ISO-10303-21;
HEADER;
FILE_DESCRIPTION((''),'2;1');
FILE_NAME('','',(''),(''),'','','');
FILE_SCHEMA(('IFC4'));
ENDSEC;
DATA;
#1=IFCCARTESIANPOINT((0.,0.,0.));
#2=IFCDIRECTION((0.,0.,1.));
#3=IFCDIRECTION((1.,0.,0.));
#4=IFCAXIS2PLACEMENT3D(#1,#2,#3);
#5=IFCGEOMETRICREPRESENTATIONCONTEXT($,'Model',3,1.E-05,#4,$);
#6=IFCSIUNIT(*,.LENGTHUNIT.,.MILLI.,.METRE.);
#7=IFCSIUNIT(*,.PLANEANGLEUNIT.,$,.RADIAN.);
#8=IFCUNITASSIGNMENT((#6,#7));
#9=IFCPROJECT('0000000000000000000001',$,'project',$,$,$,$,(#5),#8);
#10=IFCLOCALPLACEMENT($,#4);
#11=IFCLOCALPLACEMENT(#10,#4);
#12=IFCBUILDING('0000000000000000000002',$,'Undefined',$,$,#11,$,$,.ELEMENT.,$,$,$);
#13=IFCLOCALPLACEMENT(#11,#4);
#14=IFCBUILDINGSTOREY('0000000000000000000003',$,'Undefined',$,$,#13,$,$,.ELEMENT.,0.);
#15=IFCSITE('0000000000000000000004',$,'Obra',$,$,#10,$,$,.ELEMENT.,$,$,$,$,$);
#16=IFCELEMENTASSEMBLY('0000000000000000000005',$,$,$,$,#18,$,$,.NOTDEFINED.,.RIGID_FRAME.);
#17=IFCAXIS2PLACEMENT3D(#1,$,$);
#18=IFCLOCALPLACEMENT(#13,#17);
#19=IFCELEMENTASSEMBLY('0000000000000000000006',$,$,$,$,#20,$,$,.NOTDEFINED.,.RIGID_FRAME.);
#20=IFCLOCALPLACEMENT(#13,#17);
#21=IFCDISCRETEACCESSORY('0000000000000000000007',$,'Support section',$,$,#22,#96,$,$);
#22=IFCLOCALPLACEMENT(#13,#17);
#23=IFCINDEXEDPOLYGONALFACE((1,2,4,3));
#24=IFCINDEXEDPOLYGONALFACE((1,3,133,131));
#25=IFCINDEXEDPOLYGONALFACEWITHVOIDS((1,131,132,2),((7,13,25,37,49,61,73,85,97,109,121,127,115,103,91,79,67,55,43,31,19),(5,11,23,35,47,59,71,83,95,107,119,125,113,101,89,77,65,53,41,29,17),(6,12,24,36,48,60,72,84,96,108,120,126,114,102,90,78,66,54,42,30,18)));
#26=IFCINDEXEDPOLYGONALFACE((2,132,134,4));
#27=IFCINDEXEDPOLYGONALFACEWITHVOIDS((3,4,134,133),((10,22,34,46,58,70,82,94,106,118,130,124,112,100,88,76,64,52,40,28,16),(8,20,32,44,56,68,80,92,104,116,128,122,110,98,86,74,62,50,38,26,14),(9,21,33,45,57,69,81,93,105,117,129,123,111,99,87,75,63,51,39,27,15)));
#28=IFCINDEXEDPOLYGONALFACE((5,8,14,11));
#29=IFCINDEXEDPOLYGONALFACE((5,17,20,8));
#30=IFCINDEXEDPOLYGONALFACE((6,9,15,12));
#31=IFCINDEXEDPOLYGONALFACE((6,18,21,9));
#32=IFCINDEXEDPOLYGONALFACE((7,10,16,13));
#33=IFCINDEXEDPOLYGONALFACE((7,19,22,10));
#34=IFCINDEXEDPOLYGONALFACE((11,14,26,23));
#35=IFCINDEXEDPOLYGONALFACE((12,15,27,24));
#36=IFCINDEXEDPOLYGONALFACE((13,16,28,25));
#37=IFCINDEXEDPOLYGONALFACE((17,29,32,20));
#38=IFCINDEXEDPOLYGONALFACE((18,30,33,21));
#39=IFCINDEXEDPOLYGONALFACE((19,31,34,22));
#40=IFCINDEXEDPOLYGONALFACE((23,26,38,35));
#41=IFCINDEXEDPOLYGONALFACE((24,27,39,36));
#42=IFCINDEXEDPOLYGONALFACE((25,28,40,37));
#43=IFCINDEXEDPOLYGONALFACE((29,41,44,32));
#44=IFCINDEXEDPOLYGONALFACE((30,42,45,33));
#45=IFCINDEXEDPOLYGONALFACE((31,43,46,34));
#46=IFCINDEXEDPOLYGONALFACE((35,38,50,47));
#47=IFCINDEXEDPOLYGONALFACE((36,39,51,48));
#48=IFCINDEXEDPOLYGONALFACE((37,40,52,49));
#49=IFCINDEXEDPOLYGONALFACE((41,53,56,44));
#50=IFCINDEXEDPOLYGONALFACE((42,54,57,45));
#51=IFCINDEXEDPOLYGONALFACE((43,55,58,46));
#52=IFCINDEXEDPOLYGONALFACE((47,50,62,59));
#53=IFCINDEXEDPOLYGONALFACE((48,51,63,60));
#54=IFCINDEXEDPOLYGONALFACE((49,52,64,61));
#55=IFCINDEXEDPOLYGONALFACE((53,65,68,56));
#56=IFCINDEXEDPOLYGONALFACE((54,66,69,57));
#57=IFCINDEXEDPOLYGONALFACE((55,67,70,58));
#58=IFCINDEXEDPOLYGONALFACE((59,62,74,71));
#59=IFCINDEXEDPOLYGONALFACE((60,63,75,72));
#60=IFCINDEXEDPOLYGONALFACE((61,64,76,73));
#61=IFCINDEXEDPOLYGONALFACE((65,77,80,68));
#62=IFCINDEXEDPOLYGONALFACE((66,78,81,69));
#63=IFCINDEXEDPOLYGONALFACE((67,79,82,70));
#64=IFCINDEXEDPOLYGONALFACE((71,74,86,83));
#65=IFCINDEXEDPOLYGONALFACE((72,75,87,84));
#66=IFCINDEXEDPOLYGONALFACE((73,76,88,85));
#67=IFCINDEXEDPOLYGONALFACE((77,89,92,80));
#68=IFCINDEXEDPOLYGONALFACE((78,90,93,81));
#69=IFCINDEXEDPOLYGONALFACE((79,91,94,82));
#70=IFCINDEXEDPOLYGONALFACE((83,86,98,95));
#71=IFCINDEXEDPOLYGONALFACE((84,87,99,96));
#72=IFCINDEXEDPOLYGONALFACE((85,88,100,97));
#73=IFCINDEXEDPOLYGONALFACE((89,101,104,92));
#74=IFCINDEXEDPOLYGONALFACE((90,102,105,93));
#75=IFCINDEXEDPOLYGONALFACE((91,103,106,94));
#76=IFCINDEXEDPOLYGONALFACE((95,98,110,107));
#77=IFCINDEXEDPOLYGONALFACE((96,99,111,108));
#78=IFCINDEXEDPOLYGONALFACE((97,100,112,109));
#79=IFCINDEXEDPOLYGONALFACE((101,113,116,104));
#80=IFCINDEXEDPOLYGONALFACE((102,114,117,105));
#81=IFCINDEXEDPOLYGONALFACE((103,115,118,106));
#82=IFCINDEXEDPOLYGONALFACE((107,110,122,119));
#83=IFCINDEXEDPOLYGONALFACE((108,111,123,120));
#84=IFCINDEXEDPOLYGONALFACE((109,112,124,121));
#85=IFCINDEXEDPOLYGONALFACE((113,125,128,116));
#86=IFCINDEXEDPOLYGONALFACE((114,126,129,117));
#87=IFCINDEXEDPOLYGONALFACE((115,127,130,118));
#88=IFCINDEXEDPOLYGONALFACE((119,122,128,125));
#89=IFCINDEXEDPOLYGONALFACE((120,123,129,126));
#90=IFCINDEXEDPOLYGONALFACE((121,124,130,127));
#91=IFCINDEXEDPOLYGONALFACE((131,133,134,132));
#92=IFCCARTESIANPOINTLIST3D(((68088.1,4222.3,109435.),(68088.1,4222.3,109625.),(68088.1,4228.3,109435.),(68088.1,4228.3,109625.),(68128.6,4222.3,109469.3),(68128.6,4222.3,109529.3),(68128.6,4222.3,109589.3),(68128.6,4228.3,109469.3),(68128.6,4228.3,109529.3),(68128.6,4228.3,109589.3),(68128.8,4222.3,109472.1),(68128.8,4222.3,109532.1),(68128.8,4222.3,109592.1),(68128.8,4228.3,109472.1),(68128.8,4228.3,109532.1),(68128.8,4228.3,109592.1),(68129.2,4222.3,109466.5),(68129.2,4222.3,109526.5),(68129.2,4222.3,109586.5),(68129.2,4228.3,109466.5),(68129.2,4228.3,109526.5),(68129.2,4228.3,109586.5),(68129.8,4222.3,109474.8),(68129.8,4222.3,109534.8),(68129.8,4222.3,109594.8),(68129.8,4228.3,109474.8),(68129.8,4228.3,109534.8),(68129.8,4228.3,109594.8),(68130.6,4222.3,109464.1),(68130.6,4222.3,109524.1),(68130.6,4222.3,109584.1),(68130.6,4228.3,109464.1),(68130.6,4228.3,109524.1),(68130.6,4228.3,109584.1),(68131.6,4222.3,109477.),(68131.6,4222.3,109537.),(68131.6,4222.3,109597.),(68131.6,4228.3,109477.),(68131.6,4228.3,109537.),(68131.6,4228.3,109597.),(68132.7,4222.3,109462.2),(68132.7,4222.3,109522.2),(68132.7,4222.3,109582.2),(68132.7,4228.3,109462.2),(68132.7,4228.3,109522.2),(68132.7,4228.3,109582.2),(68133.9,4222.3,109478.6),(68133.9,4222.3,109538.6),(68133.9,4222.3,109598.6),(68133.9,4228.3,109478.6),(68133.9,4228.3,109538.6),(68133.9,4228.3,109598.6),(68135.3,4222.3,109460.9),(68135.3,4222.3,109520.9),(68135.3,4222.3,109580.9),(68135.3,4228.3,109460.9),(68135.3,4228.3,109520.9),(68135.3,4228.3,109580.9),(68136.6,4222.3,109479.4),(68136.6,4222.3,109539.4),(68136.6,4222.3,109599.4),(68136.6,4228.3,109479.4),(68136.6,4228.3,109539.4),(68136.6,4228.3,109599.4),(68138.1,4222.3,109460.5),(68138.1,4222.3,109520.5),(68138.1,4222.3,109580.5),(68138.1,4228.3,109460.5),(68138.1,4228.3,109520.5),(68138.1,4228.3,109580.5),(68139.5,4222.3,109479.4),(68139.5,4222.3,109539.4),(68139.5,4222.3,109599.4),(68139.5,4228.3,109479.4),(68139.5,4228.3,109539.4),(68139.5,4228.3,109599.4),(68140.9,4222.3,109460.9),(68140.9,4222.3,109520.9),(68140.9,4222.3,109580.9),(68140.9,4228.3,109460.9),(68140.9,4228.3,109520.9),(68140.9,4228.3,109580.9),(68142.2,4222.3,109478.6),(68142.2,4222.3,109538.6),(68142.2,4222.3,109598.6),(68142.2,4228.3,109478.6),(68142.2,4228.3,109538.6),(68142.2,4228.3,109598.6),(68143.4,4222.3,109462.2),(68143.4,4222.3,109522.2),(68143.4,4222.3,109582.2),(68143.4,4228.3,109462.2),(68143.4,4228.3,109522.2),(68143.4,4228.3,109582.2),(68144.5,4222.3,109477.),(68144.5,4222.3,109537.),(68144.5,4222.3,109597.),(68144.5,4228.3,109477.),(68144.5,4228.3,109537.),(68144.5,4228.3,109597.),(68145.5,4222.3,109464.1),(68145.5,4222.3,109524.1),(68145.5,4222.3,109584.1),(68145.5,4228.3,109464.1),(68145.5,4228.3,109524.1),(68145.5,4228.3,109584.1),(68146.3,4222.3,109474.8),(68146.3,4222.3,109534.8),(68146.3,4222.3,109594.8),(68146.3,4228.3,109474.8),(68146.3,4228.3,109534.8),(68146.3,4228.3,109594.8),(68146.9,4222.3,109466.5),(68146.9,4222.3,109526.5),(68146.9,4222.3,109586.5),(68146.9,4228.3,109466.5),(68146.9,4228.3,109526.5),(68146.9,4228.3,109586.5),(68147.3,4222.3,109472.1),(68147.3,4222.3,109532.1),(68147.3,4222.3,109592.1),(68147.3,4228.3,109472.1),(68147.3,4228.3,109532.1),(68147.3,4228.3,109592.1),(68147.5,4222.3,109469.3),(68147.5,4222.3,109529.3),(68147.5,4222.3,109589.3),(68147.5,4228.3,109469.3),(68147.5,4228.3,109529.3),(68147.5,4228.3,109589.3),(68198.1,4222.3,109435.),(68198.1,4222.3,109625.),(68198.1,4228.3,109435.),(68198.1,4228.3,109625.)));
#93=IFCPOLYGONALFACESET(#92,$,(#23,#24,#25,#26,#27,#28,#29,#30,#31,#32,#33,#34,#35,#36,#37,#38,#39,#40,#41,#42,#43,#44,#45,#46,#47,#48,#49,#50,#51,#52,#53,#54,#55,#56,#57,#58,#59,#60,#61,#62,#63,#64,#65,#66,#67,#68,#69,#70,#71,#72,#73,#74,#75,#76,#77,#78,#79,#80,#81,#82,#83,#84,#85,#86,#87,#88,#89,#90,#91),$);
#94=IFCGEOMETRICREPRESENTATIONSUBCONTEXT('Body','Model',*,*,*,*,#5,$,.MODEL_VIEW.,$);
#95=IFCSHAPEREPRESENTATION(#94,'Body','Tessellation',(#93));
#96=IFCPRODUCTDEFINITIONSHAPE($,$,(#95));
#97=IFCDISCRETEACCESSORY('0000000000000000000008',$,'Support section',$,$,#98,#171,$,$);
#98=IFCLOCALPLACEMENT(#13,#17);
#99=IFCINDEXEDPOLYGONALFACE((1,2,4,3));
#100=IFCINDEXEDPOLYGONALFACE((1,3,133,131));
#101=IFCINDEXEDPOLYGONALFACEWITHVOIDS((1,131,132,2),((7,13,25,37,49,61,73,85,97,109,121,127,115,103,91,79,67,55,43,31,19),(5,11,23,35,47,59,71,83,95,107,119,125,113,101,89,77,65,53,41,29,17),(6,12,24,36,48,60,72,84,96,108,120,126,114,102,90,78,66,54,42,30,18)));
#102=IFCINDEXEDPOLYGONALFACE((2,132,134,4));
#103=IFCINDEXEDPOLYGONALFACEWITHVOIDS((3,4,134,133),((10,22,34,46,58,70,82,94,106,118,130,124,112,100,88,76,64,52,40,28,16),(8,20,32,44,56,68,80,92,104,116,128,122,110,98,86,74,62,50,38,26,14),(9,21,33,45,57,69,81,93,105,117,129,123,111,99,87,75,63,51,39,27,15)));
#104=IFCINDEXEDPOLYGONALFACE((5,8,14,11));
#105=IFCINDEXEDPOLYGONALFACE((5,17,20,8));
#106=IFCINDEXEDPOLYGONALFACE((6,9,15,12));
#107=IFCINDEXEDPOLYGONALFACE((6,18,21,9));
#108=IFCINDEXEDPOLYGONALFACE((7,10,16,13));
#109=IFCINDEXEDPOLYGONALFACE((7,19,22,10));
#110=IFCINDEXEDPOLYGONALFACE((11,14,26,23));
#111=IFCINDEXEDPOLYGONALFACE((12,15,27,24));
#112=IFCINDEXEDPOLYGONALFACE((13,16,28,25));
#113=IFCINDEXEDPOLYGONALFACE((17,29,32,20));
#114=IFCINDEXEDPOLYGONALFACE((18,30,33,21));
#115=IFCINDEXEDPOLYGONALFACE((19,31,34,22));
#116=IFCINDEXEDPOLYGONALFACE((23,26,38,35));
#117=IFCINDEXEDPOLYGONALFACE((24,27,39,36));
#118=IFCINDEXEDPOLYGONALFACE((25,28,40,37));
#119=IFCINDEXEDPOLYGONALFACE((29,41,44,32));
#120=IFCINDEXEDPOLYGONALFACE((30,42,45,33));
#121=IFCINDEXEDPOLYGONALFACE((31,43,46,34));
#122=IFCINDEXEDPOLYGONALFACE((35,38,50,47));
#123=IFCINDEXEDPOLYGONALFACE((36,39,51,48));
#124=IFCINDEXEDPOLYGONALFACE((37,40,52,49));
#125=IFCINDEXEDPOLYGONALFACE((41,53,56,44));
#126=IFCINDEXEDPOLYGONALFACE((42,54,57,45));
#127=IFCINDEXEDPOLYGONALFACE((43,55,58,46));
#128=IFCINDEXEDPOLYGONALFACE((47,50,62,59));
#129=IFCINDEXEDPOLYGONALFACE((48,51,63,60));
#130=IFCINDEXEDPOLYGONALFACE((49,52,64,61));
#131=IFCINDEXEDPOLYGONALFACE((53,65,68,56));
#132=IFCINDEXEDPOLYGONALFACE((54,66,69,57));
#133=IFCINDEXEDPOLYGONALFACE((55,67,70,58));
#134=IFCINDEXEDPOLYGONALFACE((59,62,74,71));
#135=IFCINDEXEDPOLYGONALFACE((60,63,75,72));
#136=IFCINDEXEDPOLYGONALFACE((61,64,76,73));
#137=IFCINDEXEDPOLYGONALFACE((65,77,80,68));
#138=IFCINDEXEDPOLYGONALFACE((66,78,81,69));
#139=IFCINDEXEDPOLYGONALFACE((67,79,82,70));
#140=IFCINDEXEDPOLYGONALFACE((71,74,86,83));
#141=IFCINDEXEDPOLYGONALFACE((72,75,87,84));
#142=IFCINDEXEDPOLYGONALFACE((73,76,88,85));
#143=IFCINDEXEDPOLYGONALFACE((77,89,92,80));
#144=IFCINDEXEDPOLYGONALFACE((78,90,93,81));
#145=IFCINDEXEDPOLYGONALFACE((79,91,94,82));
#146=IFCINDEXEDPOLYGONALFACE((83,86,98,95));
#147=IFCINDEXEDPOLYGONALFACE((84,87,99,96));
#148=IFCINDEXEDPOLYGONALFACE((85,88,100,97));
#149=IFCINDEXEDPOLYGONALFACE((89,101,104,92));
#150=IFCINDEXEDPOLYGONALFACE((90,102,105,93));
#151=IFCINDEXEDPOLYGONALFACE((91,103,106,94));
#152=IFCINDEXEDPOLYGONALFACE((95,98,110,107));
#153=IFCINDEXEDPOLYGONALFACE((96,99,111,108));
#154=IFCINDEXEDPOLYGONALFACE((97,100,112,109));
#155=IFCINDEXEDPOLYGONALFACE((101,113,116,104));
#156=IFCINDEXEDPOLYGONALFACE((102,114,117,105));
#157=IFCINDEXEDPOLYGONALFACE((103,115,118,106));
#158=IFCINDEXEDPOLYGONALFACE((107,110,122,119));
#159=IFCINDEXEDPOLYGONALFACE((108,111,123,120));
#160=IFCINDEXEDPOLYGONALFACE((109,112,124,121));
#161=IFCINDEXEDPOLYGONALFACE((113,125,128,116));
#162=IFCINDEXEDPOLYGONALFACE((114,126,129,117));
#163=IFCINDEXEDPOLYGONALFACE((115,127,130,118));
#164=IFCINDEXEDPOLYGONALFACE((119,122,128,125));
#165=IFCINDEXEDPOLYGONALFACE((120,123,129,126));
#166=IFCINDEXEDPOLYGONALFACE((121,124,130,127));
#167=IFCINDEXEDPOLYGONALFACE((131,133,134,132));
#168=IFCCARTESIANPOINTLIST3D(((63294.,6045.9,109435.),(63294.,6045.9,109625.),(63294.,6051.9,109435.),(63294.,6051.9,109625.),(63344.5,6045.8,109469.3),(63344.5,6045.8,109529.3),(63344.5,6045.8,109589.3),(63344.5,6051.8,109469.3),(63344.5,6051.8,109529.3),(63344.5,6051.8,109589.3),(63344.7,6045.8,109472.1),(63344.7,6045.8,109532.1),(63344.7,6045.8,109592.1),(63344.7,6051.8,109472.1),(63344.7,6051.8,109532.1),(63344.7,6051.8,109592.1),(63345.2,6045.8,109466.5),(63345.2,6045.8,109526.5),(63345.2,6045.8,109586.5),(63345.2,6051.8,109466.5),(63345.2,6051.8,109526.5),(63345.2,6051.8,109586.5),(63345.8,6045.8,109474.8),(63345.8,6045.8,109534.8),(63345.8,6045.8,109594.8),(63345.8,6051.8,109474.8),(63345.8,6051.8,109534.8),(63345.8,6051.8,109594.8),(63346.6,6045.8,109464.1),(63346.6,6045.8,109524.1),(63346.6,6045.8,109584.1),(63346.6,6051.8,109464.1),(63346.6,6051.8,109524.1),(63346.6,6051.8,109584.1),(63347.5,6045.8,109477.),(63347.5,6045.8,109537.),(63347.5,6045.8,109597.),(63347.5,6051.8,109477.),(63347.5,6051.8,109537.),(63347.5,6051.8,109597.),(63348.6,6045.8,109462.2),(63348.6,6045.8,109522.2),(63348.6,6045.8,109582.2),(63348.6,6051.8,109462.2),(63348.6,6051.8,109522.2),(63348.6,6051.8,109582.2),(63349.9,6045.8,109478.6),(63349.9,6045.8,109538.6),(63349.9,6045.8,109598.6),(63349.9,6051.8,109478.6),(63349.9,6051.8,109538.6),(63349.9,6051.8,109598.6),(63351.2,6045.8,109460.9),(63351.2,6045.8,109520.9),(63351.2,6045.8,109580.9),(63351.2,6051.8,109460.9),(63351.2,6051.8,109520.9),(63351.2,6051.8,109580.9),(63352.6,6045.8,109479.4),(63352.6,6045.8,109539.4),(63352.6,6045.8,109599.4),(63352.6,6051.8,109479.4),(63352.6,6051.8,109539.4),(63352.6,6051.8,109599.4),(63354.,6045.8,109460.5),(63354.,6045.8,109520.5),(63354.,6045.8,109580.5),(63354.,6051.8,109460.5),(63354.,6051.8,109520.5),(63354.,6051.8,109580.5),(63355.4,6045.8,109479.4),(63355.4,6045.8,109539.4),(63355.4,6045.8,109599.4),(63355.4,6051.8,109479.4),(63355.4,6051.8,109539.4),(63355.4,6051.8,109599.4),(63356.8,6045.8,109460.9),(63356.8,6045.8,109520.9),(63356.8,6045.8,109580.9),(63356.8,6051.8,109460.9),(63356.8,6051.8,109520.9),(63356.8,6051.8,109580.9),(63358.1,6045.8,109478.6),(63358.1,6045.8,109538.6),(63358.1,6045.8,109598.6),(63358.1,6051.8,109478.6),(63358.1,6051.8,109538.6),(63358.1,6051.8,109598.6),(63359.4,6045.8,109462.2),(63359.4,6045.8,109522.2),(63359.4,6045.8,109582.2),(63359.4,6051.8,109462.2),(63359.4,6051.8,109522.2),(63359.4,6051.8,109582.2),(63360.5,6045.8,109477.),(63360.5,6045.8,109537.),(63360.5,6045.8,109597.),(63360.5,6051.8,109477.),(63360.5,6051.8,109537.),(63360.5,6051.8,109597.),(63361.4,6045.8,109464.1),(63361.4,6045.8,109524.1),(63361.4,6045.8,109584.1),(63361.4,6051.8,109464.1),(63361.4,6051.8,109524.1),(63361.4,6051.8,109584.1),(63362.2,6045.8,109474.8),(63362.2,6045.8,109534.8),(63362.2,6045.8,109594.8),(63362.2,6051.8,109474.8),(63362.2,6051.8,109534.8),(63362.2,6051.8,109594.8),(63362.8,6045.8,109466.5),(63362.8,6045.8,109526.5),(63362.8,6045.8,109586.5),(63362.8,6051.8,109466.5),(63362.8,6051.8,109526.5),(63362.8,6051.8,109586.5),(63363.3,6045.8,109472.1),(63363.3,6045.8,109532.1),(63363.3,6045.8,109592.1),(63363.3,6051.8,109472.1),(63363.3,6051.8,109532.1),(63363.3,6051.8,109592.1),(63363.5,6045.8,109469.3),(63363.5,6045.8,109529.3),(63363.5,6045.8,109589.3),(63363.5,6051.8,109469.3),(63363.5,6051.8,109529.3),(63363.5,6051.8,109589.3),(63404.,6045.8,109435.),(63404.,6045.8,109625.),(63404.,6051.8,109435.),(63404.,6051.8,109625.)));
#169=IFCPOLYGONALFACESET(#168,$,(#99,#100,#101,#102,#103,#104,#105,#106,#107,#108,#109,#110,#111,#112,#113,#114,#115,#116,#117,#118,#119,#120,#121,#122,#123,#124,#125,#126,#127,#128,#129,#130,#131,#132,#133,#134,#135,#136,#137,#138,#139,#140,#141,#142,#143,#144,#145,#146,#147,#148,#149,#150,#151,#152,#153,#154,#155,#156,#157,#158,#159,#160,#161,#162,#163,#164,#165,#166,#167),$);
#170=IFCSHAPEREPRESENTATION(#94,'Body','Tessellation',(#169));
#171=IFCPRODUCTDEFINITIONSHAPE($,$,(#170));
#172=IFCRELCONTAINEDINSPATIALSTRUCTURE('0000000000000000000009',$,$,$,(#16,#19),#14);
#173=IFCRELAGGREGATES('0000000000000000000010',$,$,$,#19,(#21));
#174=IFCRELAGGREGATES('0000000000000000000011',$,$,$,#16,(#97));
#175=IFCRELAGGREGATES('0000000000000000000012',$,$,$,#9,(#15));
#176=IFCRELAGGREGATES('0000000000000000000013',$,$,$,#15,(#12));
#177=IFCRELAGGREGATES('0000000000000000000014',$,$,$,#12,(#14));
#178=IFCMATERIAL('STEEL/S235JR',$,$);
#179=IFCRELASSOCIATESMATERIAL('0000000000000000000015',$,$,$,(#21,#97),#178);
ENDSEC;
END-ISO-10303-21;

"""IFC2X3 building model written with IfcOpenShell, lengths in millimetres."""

from ifc_helpers import new_model, si_unit, frame, origin_with_axes, origin_2d_with_axis, place, context, subcontext, project, spatial, rectangle, circle, extrude, source, transform, mapped, material, element, aggregate, save


model = new_model("IFC2X3")

# Units and contexts
model_context = context("Model", 3, precision=1e-05, world=origin_with_axes())
body_context = subcontext(model_context, "Body", "Model", "MODEL_VIEW")
ifc_project = project(units=[si_unit("LENGTHUNIT", "METRE", prefix="MILLI"), si_unit("PLANEANGLEUNIT", "RADIAN")], contexts=[model_context])

# Site, building, storey
site_placement = place(None, origin_with_axes())
site = spatial("IfcSite", under=ifc_project, at=site_placement, Name="Obra", CompositionType="ELEMENT")
building_placement = place(site_placement, origin_with_axes())
building = spatial("IfcBuilding", under=site, at=building_placement, Name="Undefined", CompositionType="ELEMENT")
storey_placement = place(building_placement, origin_with_axes())
storey = spatial("IfcBuildingStorey", under=building, at=storey_placement, Name="Undefined", CompositionType="ELEMENT", Elevation=0.0)

# Element assembly
assembly_1_placement = place(storey_placement, origin_with_axes())
assembly_1 = element("IfcElementAssembly", 1, at=assembly_1_placement, inside=storey, AssemblyPlace="NOTDEFINED", PredefinedType="RIGID_FRAME")
ifc_material_1 = material(Name="STEEL/S235JR")

# Shared definitions
shared_shape_1 = source(origin_with_axes(), body_context, "Body", "SweptSolid", [
    extrude(circle(Radius=9.5, at=origin_2d_with_axis()), frame((0.0, -9.2, 0.0), z_axis=(0.0, 1.0, 0.0), x_axis=(1.0, 0.0, 0.0)), (0.0, 0.0, 1.0), 6.2),
])

# Element assembly, discrete accessory, opening
assembly_2_placement = place(storey_placement, origin_with_axes())
assembly_2 = element("IfcElementAssembly", 2, at=assembly_2_placement, inside=storey, AssemblyPlace="NOTDEFINED", PredefinedType="RIGID_FRAME")
discrete_accessory_1_placement = place(assembly_2_placement, frame((68143.1, 4225.3, 109435.0), z_axis=(0.0, 0.0, 1.0), x_axis=(1.0, -0.000126, 0.0)))
discrete_accessory_1 = element("IfcDiscreteAccessory", 3, at=discrete_accessory_1_placement, material=ifc_material_1, Name="Support section", context=body_context, shape_type="SweptSolid", body=[
    extrude(rectangle(XDim=6.0, YDim=110.0, at=origin_2d_with_axis()), frame((0.0, 0.0, 190.0), z_axis=(0.0, 0.0, -1.0), x_axis=(0.0, 1.0, 0.0)), (0.0, 0.0, 1.0), 190.0),
])
opening_1_placement = place(assembly_2_placement, frame((68188.1, 4219.2, 109650.0), z_axis=(-1.0, 0.000126, 0.0), x_axis=(0.0, 0.0, -1.0)))
element("IfcOpeningElement", 4, at=opening_1_placement, cuts=discrete_accessory_1, ObjectType="Opening", context=body_context, shape_type="MappedRepresentation", body=[
    mapped(shared_shape_1, transform((60.0, 0.0, 50.0))),
    mapped(shared_shape_1, transform((120.0, 0.0, 50.0))),
    mapped(shared_shape_1, transform((180.0, 0.0, 50.0))),
])
aggregate(assembly_2, [discrete_accessory_1])

# Discrete accessory, opening
discrete_accessory_2_placement = place(assembly_1_placement, frame((63349.0, 6048.8, 109435.0), z_axis=(0.0, 0.0, 1.0), x_axis=(-1.0, 0.000126, 0.0)))
discrete_accessory_2 = element("IfcDiscreteAccessory", 5, at=discrete_accessory_2_placement, material=ifc_material_1, Name="Support section", context=body_context, shape_type="SweptSolid", body=[
    extrude(rectangle(XDim=6.0, YDim=110.0, at=origin_2d_with_axis()), frame((0.0, 0.0, 190.0), z_axis=(0.0, 0.0, -1.0), x_axis=(0.0, 1.0, 0.0)), (0.0, 0.0, 1.0), 190.0),
])
opening_2_placement = place(assembly_1_placement, frame((63304.0, 6055.0, 109650.0), z_axis=(1.0, -0.000126, 0.0), x_axis=(0.0, 0.0, -1.0)))
element("IfcOpeningElement", 6, at=opening_2_placement, cuts=discrete_accessory_2, ObjectType="Opening", context=body_context, shape_type="MappedRepresentation", body=[
    mapped(shared_shape_1, transform((60.0, 0.0, 50.0))),
    mapped(shared_shape_1, transform((120.0, 0.0, 50.0))),
    mapped(shared_shape_1, transform((180.0, 0.0, 50.0))),
])
aggregate(assembly_1, [discrete_accessory_2])

save(model, "model.ifc")
